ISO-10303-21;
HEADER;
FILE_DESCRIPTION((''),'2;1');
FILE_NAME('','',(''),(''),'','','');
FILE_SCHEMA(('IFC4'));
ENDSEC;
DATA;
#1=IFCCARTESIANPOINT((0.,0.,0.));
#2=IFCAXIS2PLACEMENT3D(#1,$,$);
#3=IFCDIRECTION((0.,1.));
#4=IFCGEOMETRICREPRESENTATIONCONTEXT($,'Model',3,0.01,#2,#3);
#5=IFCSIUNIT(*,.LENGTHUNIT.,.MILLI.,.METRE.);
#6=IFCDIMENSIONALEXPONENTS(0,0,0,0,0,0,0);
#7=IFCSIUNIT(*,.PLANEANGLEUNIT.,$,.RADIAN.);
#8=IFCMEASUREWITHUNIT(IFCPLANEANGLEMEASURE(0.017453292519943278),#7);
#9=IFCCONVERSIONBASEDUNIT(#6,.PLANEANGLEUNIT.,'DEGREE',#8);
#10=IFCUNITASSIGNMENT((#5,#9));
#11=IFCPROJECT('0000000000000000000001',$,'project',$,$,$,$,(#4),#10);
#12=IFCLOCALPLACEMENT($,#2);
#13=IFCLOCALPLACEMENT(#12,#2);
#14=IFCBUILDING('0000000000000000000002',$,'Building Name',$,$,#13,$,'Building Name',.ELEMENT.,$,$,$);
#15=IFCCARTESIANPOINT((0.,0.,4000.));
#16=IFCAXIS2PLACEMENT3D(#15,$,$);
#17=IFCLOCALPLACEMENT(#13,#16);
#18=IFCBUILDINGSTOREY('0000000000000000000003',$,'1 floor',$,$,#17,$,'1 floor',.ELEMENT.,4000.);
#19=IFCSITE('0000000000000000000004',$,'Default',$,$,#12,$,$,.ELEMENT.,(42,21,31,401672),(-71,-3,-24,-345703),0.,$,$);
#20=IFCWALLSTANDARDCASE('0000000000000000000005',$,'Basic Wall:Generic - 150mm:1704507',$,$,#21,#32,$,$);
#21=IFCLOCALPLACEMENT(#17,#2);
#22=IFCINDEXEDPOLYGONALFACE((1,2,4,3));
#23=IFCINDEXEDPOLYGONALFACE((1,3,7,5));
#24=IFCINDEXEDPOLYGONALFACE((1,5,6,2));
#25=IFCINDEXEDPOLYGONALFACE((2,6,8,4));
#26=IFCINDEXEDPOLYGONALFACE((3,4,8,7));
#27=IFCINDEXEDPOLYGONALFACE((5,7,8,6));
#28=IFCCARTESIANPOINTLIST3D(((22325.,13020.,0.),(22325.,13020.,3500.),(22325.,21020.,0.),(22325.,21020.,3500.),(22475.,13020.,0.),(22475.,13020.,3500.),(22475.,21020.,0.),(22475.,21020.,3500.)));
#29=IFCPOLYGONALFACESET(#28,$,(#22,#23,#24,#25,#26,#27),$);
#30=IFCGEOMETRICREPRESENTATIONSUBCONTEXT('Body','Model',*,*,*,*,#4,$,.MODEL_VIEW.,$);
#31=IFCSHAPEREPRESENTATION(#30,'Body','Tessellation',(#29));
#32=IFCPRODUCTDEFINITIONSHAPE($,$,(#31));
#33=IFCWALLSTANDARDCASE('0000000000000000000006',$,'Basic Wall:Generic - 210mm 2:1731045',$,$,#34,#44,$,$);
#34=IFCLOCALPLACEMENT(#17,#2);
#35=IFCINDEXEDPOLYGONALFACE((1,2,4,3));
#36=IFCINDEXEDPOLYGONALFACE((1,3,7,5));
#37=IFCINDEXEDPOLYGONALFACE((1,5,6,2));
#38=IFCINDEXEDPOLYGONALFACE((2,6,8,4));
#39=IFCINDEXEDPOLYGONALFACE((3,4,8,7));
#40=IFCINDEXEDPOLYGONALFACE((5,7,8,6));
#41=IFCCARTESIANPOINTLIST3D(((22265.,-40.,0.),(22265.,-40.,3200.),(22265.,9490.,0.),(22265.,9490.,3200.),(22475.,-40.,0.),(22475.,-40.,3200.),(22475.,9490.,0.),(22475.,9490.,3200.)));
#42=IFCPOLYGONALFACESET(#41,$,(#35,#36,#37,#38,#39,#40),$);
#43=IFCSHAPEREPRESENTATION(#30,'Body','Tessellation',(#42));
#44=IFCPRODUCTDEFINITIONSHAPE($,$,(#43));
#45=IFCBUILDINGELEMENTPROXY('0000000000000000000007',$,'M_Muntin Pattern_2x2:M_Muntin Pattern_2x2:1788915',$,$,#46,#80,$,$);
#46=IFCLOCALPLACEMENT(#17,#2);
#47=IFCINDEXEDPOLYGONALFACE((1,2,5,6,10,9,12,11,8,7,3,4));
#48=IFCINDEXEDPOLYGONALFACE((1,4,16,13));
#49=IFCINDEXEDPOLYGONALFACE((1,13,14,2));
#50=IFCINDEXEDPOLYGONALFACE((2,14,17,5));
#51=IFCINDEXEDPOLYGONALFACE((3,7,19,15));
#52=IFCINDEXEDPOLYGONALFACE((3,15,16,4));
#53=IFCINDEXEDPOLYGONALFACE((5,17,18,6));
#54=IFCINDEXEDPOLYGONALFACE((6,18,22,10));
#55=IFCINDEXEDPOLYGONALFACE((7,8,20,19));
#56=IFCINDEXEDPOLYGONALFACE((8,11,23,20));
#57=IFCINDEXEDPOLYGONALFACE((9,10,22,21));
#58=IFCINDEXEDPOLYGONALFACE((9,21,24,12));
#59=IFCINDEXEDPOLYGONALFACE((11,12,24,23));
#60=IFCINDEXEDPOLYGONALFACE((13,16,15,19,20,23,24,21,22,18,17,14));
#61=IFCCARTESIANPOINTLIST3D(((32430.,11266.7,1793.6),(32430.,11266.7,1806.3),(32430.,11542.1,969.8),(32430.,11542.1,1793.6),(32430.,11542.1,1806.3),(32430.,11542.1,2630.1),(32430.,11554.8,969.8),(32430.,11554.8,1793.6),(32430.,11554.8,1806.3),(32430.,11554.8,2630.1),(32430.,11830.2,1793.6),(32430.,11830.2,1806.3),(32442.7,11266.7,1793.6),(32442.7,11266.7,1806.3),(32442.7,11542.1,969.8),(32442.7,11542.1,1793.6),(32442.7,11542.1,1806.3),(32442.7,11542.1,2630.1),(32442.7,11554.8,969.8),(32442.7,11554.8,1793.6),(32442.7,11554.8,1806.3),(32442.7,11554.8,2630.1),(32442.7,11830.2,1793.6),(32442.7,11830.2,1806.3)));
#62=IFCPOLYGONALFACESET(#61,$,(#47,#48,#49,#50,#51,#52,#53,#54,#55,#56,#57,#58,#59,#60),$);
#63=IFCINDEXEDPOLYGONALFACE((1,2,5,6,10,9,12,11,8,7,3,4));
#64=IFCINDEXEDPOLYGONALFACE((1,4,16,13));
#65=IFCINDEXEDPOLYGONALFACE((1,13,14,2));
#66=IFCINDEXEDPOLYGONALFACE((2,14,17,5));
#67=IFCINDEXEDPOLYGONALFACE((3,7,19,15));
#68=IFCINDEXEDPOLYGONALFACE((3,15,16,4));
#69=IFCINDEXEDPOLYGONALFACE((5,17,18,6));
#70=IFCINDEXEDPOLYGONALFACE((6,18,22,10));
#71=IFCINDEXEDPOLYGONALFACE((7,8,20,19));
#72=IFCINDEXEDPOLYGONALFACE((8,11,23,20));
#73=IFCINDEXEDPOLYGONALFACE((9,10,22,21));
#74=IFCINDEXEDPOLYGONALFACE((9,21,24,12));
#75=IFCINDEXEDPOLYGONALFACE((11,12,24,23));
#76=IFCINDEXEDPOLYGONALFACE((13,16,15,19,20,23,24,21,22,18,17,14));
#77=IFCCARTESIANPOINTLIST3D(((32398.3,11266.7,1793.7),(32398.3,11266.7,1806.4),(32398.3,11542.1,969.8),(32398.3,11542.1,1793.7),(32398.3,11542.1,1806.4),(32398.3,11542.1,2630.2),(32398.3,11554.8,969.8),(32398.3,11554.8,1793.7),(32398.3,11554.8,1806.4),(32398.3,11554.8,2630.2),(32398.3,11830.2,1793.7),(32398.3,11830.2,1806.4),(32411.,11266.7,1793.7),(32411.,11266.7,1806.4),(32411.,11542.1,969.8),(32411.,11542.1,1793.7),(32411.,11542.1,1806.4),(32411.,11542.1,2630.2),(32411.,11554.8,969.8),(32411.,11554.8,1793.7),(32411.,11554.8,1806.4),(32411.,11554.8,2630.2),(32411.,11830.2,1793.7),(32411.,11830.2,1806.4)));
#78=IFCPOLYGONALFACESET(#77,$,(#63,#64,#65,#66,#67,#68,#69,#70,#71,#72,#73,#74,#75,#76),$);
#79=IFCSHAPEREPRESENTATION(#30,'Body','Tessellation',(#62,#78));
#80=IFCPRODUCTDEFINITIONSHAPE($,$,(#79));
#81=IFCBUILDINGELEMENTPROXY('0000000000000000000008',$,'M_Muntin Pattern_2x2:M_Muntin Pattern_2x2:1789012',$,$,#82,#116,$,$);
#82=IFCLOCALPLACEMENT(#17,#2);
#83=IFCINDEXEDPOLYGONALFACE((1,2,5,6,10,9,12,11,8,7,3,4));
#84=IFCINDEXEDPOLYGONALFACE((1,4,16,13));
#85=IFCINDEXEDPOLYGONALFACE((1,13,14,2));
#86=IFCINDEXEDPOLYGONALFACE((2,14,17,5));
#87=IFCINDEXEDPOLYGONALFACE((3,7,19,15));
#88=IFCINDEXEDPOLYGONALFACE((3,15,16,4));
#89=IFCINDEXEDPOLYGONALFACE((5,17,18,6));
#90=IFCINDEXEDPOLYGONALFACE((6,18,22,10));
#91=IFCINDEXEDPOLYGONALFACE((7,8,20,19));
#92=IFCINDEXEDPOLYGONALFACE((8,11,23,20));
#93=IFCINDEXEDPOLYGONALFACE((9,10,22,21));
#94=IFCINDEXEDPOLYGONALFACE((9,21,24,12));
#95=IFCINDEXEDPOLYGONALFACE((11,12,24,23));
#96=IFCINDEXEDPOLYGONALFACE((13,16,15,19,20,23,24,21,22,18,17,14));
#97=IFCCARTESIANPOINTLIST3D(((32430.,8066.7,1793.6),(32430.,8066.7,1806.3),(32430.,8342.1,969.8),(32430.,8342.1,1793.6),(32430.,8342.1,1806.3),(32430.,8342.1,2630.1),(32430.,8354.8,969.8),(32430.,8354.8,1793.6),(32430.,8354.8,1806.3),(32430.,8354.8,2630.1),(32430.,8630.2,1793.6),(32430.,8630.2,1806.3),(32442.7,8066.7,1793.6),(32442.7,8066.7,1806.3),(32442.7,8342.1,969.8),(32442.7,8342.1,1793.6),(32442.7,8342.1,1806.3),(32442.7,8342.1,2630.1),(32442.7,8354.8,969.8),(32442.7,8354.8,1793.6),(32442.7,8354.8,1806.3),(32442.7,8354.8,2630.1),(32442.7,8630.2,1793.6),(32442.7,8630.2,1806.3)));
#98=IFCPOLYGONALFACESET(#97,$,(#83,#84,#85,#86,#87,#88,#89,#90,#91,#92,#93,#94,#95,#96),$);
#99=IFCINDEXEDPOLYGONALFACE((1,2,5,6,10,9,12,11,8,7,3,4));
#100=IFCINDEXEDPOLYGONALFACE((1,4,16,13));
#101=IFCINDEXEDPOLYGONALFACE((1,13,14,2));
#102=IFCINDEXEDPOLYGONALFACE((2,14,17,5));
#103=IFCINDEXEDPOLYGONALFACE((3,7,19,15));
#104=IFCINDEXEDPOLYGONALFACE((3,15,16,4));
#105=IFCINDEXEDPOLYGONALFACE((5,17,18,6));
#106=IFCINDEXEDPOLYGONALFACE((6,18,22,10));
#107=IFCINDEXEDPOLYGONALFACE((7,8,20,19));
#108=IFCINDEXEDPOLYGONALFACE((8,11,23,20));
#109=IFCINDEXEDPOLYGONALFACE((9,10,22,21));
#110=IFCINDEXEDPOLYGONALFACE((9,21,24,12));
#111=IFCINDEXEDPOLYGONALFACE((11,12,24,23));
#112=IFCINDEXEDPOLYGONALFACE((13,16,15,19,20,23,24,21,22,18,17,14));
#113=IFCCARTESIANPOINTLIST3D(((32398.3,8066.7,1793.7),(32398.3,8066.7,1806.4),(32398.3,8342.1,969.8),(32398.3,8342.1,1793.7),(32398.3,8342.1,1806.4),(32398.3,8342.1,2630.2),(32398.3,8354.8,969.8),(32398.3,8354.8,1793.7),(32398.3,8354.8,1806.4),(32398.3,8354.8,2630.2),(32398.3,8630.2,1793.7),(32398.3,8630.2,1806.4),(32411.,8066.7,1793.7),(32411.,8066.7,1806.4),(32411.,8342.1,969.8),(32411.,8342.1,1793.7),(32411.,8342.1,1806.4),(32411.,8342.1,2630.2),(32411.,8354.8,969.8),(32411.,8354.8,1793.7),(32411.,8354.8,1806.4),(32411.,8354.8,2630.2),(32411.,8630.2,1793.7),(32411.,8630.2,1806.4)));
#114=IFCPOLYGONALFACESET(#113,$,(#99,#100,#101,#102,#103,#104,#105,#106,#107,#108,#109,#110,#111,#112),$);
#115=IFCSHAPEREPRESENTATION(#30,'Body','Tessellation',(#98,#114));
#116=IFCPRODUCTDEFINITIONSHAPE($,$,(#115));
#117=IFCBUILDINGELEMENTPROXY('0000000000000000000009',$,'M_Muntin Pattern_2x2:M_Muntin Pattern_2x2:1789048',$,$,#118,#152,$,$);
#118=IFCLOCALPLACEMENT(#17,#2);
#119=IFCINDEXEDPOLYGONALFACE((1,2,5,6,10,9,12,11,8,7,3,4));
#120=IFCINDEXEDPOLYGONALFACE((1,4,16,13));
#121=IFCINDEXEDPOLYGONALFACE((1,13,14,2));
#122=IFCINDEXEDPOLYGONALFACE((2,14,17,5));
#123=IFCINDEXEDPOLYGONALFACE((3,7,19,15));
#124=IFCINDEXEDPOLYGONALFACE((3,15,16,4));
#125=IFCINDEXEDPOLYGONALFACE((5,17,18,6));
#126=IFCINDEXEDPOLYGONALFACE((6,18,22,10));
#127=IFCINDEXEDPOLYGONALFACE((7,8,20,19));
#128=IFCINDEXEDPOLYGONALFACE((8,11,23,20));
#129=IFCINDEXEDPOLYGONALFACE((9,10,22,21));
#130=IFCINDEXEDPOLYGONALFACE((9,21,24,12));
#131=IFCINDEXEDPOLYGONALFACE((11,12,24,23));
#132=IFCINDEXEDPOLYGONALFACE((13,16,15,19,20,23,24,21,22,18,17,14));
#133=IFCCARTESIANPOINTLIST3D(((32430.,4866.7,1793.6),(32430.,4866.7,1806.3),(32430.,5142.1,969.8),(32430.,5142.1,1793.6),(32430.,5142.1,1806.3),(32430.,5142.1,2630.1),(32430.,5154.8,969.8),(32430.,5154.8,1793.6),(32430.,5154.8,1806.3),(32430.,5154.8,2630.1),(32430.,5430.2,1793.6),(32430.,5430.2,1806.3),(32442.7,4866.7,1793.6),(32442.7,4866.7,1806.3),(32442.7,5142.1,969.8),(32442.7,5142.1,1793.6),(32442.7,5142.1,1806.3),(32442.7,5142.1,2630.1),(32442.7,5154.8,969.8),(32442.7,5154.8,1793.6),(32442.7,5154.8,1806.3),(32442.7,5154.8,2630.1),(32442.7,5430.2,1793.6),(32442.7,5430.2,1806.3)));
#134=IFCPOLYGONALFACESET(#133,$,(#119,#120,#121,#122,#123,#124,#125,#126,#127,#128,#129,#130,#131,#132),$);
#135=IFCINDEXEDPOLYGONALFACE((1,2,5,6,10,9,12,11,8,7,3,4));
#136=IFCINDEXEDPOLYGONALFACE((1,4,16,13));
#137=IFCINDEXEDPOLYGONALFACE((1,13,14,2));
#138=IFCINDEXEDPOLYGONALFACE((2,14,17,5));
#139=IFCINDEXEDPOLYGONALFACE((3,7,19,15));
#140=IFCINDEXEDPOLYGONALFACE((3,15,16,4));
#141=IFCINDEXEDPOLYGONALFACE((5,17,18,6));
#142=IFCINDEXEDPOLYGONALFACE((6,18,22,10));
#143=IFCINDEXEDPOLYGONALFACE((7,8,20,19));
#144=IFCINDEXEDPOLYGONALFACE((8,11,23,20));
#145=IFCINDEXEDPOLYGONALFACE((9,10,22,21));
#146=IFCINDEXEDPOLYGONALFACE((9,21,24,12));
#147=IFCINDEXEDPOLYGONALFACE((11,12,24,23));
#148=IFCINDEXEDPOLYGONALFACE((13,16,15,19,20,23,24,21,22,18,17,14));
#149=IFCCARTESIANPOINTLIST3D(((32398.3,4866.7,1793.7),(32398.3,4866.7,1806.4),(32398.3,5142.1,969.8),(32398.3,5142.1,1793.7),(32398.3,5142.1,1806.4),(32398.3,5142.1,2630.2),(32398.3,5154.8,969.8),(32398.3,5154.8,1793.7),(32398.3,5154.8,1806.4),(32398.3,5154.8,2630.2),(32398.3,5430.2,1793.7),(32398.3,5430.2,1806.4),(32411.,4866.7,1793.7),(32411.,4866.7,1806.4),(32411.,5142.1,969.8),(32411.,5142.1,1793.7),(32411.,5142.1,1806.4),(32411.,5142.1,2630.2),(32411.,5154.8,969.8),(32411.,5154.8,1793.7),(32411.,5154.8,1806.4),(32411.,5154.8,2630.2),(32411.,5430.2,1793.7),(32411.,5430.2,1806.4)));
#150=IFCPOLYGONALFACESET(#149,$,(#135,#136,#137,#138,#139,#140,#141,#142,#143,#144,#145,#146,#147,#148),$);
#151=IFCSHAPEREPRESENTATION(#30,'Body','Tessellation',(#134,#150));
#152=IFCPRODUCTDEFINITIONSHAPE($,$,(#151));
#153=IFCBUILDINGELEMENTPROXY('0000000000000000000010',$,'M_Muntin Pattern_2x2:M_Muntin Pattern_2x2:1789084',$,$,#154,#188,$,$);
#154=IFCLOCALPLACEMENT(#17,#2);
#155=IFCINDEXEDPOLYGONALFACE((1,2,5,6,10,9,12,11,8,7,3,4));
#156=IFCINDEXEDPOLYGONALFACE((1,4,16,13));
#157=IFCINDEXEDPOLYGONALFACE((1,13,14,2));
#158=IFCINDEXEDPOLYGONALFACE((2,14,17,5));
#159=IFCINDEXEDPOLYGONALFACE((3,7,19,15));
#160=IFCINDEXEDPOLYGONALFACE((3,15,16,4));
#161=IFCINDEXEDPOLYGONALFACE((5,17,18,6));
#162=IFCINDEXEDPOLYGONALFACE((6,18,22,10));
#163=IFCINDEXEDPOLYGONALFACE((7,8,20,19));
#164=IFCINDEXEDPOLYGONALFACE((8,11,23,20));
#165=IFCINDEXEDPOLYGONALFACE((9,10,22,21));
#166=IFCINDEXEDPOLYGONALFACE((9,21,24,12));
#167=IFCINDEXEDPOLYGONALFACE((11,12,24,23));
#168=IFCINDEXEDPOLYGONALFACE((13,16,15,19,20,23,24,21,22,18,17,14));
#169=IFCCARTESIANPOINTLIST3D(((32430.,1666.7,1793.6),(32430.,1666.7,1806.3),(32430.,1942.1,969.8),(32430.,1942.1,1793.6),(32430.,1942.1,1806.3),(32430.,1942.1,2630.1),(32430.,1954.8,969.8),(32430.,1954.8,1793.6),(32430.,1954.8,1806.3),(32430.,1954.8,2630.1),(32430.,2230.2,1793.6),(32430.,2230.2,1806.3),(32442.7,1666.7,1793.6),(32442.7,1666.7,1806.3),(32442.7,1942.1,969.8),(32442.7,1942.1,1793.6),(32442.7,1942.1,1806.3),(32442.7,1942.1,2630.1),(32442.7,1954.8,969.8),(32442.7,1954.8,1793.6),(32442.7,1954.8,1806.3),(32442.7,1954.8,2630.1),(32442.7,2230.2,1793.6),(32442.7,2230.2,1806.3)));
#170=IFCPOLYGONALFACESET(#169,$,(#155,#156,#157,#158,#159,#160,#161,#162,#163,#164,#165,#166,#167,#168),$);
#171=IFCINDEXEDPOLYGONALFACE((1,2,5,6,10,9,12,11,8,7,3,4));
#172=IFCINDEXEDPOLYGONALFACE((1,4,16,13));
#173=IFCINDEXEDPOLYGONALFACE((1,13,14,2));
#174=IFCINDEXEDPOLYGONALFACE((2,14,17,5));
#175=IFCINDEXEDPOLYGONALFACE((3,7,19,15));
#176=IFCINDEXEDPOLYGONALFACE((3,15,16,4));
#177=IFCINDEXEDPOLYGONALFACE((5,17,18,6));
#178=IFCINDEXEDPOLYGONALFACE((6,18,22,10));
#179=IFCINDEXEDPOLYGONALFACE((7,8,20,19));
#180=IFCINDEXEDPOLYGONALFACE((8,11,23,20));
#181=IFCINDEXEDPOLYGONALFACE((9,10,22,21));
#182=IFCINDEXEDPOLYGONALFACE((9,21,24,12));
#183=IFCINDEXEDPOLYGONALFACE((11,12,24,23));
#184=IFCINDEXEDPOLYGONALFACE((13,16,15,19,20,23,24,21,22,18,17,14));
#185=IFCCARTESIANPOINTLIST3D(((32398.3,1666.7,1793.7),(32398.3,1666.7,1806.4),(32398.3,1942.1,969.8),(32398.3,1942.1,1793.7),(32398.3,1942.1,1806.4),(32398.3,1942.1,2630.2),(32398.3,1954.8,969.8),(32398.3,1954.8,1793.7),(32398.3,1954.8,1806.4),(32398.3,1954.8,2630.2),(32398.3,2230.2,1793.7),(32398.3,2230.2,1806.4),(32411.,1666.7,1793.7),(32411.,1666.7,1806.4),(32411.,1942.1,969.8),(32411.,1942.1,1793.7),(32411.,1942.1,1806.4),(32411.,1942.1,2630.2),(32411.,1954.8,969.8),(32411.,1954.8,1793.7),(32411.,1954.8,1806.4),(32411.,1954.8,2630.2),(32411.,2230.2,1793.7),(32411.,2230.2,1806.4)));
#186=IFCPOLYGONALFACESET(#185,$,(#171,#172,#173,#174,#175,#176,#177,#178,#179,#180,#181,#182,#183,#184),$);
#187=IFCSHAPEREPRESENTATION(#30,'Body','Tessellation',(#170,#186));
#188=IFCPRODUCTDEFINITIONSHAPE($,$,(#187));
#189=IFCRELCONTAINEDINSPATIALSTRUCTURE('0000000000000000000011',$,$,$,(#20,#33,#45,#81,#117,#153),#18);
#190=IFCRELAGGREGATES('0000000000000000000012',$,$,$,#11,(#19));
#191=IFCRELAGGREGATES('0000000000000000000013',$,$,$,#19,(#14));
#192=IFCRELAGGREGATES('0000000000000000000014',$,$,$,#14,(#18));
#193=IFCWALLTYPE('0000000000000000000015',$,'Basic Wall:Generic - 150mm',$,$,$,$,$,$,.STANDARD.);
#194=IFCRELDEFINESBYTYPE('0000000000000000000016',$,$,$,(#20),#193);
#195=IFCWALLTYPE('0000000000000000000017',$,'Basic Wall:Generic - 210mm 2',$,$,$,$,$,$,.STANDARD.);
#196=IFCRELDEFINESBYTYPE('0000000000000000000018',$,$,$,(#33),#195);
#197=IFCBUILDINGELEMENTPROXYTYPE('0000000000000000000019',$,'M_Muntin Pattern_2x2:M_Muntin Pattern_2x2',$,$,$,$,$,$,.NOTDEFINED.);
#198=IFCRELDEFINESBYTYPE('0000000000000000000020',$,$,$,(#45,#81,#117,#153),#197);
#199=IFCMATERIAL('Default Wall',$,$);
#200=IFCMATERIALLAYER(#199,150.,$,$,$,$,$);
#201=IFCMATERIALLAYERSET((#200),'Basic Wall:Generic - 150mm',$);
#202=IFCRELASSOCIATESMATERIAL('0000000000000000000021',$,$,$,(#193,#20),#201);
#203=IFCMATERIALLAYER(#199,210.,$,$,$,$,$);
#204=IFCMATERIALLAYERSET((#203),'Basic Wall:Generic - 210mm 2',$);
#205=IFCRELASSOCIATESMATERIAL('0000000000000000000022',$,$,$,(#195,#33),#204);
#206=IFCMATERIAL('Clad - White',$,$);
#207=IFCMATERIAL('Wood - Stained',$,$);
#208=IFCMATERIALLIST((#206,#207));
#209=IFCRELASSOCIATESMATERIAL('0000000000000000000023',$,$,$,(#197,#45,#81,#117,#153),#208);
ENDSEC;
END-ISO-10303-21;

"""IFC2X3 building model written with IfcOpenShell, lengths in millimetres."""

from ifc_helpers import new_model, entity, si_unit, converted_unit, direction, frame, frame_2d, origin, place, context, subcontext, project, spatial, polyline, rectangle, outline, extrude, clip, bounded_halfspace, source, transform, mapped, material, material_list, layer, layer_set, layer_usage, type_object, type_shapes, element, save


model = new_model("IFC2X3")

# Units and contexts
model_context = context("Model", 3, precision=0.01, world=origin(), true_north=direction((0.0, 1.0)))
body_context = subcontext(model_context, "Body", "Model", "MODEL_VIEW")
ifc_project = project(units=[si_unit("LENGTHUNIT", "METRE", prefix="MILLI"), converted_unit("PLANEANGLEUNIT", "DEGREE", entity("IfcPlaneAngleMeasure", 0.017453292519943278), si_unit("PLANEANGLEUNIT", "RADIAN"), dimensions=[0, 0, 0, 0, 0, 0, 0])], contexts=[model_context])

# Site, building, storey
site_placement = place(None, origin())
site = spatial("IfcSite", under=ifc_project, at=site_placement, Name="Default", CompositionType="ELEMENT", RefLatitude=(42, 21, 31, 401672), RefLongitude=(-71, -3, -24, -345703), RefElevation=0.0)
building_placement = place(site_placement, origin())
building = spatial("IfcBuilding", under=site, at=building_placement, Name="Building Name", LongName="Building Name", CompositionType="ELEMENT")
storey_placement = place(building_placement, frame((0.0, 0.0, 4000.0)))
storey = spatial("IfcBuildingStorey", under=building, at=storey_placement, Name="1 floor", LongName="1 floor", CompositionType="ELEMENT", Elevation=4000.0)

# Walls
ifc_material_1 = material(Name="Default Wall")
ifc_layer_1 = layer(ifc_material_1, 150.0)
ifc_layer_set_1 = layer_set([ifc_layer_1], Name="Basic Wall:Generic - 150mm")
ifc_layer_usage_1 = layer_usage(ifc_layer_set_1, "AXIS2", "NEGATIVE", 75.0)
wall_type_1 = type_object("IfcWallType", Name="Basic Wall:Generic - 150mm", PredefinedType="STANDARD", material=ifc_layer_set_1)
wall_1_placement = place(storey_placement, frame((22400.0, 13020.0, 0.0), z_axis=(0.0, 0.0, 1.0), x_axis=(0.0, 1.0, 0.0)))
element("IfcWallStandardCase", 1, at=wall_1_placement, inside=storey, type_object=wall_type_1, material=ifc_layer_usage_1, Name="Basic Wall:Generic - 150mm:1704507", context=body_context, shape_type="SweptSolid", body=[
    extrude(rectangle(XDim=8000.0, YDim=150.0, at=frame_2d((4000.0, 0.0), x_axis=(-1.0, 0.0))), origin(), (0.0, 0.0, 1.0), 3500.0),
])
ifc_layer_2 = layer(ifc_material_1, 210.0)
ifc_layer_set_2 = layer_set([ifc_layer_2], Name="Basic Wall:Generic - 210mm 2")
ifc_layer_usage_2 = layer_usage(ifc_layer_set_2, "AXIS2", "NEGATIVE", 105.0)
wall_type_2 = type_object("IfcWallType", Name="Basic Wall:Generic - 210mm 2", PredefinedType="STANDARD", material=ifc_layer_set_2)
wall_2_placement = place(storey_placement, frame((22370.0, 9490.0, 0.0), z_axis=(0.0, 0.0, 1.0), x_axis=(0.0, -1.0, 0.0)))
element("IfcWallStandardCase", 2, at=wall_2_placement, inside=storey, type_object=wall_type_2, material=ifc_layer_usage_2, Name="Basic Wall:Generic - 210mm 2:1731045", context=body_context, shape_type="Clipping", body=[
    clip(extrude(rectangle(XDim=9530.0, YDim=210.0, at=frame_2d((4765.0, 0.0), x_axis=(-1.0, 0.0))), origin(), (0.0, 0.0, 1.0), 3200.0), bounded_halfspace(frame((0.0, -105.0, 3200.0), z_axis=(0.0, 0.0, -1.0), x_axis=(-1.0, 0.0, 0.0)), True, frame((0.0, -105.0, 3200.0)), polyline([(0.0, 0.0), (9530.0, 0.0), (9530.0, 210.0), (0.0, 210.0), (0.0, 0.0)]))),
])

# Building element proxies
ifc_material_2 = material(Name="Clad - White")
ifc_material_3 = material(Name="Wood - Stained")
ifc_material_list = material_list([ifc_material_2, ifc_material_3])
building_element_proxy_type_1 = type_object("IfcBuildingElementProxyType", Name="M_Muntin Pattern_2x2:M_Muntin Pattern_2x2", PredefinedType="NOTDEFINED", material=ifc_material_list)
shared_shape_1 = source(origin(), body_context, "Body", "SweptSolid", [
    extrude(outline(polyline([(6.4, -6.4), (830.1, -6.4), (830.1, 6.3), (6.4, 6.3), (6.4, 281.7), (-6.3, 281.7), (-6.3, 6.3), (-830.2, 6.3), (-830.2, -6.4), (-6.3, -6.4), (-6.3, -281.7), (6.4, -281.7), (6.4, -6.4)])), frame((0.0, 9.5, 830.1), z_axis=(0.0, 1.0, 0.0), x_axis=(0.0, 0.0, 1.0)), (0.0, 0.0, 1.0), 12.7),
    extrude(outline(polyline([(6.4, -6.4), (830.2, -6.4), (830.2, 6.3), (6.4, 6.3), (6.4, 281.7), (-6.3, 281.7), (-6.3, 6.3), (-830.2, 6.3), (-830.2, -6.4), (-6.3, -6.4), (-6.3, -281.7), (6.4, -281.7), (6.4, -6.4)])), frame((0.0, -22.2, 830.2), z_axis=(0.0, 1.0, 0.0), x_axis=(0.0, 0.0, 1.0)), (0.0, 0.0, 1.0), 12.7),
])
type_shapes(building_element_proxy_type_1, [shared_shape_1])
for number, where, z_axis, x_axis, name in (
    (3, (32420.5, 11548.4, 969.8), (0.0, 0.0, 1.0), (0.0, -1.0, 0.0), "M_Muntin Pattern_2x2:M_Muntin Pattern_2x2:1788915"),
    (4, (32420.5, 8348.4, 969.8), (0.0, 0.0, 1.0), (0.0, -1.0, 0.0), "M_Muntin Pattern_2x2:M_Muntin Pattern_2x2:1789012"),
    (5, (32420.5, 5148.4, 969.8), (0.0, 0.0, 1.0), (0.0, -1.0, 0.0), "M_Muntin Pattern_2x2:M_Muntin Pattern_2x2:1789048"),
    (6, (32420.5, 1948.4, 969.8), (0.0, 0.0, 1.0), (0.0, -1.0, 0.0), "M_Muntin Pattern_2x2:M_Muntin Pattern_2x2:1789084"),
):
    element("IfcBuildingElementProxy", number, at=place(storey_placement, frame(where, z_axis=z_axis, x_axis=x_axis)), inside=storey, type_object=building_element_proxy_type_1, material=ifc_material_list, Name=name, context=body_context, shape_type="MappedRepresentation", body=[
        mapped(shared_shape_1, transform((0.0, 0.0, 0.0), scale=1.0)),
    ])

save(model, "model.ifc")
